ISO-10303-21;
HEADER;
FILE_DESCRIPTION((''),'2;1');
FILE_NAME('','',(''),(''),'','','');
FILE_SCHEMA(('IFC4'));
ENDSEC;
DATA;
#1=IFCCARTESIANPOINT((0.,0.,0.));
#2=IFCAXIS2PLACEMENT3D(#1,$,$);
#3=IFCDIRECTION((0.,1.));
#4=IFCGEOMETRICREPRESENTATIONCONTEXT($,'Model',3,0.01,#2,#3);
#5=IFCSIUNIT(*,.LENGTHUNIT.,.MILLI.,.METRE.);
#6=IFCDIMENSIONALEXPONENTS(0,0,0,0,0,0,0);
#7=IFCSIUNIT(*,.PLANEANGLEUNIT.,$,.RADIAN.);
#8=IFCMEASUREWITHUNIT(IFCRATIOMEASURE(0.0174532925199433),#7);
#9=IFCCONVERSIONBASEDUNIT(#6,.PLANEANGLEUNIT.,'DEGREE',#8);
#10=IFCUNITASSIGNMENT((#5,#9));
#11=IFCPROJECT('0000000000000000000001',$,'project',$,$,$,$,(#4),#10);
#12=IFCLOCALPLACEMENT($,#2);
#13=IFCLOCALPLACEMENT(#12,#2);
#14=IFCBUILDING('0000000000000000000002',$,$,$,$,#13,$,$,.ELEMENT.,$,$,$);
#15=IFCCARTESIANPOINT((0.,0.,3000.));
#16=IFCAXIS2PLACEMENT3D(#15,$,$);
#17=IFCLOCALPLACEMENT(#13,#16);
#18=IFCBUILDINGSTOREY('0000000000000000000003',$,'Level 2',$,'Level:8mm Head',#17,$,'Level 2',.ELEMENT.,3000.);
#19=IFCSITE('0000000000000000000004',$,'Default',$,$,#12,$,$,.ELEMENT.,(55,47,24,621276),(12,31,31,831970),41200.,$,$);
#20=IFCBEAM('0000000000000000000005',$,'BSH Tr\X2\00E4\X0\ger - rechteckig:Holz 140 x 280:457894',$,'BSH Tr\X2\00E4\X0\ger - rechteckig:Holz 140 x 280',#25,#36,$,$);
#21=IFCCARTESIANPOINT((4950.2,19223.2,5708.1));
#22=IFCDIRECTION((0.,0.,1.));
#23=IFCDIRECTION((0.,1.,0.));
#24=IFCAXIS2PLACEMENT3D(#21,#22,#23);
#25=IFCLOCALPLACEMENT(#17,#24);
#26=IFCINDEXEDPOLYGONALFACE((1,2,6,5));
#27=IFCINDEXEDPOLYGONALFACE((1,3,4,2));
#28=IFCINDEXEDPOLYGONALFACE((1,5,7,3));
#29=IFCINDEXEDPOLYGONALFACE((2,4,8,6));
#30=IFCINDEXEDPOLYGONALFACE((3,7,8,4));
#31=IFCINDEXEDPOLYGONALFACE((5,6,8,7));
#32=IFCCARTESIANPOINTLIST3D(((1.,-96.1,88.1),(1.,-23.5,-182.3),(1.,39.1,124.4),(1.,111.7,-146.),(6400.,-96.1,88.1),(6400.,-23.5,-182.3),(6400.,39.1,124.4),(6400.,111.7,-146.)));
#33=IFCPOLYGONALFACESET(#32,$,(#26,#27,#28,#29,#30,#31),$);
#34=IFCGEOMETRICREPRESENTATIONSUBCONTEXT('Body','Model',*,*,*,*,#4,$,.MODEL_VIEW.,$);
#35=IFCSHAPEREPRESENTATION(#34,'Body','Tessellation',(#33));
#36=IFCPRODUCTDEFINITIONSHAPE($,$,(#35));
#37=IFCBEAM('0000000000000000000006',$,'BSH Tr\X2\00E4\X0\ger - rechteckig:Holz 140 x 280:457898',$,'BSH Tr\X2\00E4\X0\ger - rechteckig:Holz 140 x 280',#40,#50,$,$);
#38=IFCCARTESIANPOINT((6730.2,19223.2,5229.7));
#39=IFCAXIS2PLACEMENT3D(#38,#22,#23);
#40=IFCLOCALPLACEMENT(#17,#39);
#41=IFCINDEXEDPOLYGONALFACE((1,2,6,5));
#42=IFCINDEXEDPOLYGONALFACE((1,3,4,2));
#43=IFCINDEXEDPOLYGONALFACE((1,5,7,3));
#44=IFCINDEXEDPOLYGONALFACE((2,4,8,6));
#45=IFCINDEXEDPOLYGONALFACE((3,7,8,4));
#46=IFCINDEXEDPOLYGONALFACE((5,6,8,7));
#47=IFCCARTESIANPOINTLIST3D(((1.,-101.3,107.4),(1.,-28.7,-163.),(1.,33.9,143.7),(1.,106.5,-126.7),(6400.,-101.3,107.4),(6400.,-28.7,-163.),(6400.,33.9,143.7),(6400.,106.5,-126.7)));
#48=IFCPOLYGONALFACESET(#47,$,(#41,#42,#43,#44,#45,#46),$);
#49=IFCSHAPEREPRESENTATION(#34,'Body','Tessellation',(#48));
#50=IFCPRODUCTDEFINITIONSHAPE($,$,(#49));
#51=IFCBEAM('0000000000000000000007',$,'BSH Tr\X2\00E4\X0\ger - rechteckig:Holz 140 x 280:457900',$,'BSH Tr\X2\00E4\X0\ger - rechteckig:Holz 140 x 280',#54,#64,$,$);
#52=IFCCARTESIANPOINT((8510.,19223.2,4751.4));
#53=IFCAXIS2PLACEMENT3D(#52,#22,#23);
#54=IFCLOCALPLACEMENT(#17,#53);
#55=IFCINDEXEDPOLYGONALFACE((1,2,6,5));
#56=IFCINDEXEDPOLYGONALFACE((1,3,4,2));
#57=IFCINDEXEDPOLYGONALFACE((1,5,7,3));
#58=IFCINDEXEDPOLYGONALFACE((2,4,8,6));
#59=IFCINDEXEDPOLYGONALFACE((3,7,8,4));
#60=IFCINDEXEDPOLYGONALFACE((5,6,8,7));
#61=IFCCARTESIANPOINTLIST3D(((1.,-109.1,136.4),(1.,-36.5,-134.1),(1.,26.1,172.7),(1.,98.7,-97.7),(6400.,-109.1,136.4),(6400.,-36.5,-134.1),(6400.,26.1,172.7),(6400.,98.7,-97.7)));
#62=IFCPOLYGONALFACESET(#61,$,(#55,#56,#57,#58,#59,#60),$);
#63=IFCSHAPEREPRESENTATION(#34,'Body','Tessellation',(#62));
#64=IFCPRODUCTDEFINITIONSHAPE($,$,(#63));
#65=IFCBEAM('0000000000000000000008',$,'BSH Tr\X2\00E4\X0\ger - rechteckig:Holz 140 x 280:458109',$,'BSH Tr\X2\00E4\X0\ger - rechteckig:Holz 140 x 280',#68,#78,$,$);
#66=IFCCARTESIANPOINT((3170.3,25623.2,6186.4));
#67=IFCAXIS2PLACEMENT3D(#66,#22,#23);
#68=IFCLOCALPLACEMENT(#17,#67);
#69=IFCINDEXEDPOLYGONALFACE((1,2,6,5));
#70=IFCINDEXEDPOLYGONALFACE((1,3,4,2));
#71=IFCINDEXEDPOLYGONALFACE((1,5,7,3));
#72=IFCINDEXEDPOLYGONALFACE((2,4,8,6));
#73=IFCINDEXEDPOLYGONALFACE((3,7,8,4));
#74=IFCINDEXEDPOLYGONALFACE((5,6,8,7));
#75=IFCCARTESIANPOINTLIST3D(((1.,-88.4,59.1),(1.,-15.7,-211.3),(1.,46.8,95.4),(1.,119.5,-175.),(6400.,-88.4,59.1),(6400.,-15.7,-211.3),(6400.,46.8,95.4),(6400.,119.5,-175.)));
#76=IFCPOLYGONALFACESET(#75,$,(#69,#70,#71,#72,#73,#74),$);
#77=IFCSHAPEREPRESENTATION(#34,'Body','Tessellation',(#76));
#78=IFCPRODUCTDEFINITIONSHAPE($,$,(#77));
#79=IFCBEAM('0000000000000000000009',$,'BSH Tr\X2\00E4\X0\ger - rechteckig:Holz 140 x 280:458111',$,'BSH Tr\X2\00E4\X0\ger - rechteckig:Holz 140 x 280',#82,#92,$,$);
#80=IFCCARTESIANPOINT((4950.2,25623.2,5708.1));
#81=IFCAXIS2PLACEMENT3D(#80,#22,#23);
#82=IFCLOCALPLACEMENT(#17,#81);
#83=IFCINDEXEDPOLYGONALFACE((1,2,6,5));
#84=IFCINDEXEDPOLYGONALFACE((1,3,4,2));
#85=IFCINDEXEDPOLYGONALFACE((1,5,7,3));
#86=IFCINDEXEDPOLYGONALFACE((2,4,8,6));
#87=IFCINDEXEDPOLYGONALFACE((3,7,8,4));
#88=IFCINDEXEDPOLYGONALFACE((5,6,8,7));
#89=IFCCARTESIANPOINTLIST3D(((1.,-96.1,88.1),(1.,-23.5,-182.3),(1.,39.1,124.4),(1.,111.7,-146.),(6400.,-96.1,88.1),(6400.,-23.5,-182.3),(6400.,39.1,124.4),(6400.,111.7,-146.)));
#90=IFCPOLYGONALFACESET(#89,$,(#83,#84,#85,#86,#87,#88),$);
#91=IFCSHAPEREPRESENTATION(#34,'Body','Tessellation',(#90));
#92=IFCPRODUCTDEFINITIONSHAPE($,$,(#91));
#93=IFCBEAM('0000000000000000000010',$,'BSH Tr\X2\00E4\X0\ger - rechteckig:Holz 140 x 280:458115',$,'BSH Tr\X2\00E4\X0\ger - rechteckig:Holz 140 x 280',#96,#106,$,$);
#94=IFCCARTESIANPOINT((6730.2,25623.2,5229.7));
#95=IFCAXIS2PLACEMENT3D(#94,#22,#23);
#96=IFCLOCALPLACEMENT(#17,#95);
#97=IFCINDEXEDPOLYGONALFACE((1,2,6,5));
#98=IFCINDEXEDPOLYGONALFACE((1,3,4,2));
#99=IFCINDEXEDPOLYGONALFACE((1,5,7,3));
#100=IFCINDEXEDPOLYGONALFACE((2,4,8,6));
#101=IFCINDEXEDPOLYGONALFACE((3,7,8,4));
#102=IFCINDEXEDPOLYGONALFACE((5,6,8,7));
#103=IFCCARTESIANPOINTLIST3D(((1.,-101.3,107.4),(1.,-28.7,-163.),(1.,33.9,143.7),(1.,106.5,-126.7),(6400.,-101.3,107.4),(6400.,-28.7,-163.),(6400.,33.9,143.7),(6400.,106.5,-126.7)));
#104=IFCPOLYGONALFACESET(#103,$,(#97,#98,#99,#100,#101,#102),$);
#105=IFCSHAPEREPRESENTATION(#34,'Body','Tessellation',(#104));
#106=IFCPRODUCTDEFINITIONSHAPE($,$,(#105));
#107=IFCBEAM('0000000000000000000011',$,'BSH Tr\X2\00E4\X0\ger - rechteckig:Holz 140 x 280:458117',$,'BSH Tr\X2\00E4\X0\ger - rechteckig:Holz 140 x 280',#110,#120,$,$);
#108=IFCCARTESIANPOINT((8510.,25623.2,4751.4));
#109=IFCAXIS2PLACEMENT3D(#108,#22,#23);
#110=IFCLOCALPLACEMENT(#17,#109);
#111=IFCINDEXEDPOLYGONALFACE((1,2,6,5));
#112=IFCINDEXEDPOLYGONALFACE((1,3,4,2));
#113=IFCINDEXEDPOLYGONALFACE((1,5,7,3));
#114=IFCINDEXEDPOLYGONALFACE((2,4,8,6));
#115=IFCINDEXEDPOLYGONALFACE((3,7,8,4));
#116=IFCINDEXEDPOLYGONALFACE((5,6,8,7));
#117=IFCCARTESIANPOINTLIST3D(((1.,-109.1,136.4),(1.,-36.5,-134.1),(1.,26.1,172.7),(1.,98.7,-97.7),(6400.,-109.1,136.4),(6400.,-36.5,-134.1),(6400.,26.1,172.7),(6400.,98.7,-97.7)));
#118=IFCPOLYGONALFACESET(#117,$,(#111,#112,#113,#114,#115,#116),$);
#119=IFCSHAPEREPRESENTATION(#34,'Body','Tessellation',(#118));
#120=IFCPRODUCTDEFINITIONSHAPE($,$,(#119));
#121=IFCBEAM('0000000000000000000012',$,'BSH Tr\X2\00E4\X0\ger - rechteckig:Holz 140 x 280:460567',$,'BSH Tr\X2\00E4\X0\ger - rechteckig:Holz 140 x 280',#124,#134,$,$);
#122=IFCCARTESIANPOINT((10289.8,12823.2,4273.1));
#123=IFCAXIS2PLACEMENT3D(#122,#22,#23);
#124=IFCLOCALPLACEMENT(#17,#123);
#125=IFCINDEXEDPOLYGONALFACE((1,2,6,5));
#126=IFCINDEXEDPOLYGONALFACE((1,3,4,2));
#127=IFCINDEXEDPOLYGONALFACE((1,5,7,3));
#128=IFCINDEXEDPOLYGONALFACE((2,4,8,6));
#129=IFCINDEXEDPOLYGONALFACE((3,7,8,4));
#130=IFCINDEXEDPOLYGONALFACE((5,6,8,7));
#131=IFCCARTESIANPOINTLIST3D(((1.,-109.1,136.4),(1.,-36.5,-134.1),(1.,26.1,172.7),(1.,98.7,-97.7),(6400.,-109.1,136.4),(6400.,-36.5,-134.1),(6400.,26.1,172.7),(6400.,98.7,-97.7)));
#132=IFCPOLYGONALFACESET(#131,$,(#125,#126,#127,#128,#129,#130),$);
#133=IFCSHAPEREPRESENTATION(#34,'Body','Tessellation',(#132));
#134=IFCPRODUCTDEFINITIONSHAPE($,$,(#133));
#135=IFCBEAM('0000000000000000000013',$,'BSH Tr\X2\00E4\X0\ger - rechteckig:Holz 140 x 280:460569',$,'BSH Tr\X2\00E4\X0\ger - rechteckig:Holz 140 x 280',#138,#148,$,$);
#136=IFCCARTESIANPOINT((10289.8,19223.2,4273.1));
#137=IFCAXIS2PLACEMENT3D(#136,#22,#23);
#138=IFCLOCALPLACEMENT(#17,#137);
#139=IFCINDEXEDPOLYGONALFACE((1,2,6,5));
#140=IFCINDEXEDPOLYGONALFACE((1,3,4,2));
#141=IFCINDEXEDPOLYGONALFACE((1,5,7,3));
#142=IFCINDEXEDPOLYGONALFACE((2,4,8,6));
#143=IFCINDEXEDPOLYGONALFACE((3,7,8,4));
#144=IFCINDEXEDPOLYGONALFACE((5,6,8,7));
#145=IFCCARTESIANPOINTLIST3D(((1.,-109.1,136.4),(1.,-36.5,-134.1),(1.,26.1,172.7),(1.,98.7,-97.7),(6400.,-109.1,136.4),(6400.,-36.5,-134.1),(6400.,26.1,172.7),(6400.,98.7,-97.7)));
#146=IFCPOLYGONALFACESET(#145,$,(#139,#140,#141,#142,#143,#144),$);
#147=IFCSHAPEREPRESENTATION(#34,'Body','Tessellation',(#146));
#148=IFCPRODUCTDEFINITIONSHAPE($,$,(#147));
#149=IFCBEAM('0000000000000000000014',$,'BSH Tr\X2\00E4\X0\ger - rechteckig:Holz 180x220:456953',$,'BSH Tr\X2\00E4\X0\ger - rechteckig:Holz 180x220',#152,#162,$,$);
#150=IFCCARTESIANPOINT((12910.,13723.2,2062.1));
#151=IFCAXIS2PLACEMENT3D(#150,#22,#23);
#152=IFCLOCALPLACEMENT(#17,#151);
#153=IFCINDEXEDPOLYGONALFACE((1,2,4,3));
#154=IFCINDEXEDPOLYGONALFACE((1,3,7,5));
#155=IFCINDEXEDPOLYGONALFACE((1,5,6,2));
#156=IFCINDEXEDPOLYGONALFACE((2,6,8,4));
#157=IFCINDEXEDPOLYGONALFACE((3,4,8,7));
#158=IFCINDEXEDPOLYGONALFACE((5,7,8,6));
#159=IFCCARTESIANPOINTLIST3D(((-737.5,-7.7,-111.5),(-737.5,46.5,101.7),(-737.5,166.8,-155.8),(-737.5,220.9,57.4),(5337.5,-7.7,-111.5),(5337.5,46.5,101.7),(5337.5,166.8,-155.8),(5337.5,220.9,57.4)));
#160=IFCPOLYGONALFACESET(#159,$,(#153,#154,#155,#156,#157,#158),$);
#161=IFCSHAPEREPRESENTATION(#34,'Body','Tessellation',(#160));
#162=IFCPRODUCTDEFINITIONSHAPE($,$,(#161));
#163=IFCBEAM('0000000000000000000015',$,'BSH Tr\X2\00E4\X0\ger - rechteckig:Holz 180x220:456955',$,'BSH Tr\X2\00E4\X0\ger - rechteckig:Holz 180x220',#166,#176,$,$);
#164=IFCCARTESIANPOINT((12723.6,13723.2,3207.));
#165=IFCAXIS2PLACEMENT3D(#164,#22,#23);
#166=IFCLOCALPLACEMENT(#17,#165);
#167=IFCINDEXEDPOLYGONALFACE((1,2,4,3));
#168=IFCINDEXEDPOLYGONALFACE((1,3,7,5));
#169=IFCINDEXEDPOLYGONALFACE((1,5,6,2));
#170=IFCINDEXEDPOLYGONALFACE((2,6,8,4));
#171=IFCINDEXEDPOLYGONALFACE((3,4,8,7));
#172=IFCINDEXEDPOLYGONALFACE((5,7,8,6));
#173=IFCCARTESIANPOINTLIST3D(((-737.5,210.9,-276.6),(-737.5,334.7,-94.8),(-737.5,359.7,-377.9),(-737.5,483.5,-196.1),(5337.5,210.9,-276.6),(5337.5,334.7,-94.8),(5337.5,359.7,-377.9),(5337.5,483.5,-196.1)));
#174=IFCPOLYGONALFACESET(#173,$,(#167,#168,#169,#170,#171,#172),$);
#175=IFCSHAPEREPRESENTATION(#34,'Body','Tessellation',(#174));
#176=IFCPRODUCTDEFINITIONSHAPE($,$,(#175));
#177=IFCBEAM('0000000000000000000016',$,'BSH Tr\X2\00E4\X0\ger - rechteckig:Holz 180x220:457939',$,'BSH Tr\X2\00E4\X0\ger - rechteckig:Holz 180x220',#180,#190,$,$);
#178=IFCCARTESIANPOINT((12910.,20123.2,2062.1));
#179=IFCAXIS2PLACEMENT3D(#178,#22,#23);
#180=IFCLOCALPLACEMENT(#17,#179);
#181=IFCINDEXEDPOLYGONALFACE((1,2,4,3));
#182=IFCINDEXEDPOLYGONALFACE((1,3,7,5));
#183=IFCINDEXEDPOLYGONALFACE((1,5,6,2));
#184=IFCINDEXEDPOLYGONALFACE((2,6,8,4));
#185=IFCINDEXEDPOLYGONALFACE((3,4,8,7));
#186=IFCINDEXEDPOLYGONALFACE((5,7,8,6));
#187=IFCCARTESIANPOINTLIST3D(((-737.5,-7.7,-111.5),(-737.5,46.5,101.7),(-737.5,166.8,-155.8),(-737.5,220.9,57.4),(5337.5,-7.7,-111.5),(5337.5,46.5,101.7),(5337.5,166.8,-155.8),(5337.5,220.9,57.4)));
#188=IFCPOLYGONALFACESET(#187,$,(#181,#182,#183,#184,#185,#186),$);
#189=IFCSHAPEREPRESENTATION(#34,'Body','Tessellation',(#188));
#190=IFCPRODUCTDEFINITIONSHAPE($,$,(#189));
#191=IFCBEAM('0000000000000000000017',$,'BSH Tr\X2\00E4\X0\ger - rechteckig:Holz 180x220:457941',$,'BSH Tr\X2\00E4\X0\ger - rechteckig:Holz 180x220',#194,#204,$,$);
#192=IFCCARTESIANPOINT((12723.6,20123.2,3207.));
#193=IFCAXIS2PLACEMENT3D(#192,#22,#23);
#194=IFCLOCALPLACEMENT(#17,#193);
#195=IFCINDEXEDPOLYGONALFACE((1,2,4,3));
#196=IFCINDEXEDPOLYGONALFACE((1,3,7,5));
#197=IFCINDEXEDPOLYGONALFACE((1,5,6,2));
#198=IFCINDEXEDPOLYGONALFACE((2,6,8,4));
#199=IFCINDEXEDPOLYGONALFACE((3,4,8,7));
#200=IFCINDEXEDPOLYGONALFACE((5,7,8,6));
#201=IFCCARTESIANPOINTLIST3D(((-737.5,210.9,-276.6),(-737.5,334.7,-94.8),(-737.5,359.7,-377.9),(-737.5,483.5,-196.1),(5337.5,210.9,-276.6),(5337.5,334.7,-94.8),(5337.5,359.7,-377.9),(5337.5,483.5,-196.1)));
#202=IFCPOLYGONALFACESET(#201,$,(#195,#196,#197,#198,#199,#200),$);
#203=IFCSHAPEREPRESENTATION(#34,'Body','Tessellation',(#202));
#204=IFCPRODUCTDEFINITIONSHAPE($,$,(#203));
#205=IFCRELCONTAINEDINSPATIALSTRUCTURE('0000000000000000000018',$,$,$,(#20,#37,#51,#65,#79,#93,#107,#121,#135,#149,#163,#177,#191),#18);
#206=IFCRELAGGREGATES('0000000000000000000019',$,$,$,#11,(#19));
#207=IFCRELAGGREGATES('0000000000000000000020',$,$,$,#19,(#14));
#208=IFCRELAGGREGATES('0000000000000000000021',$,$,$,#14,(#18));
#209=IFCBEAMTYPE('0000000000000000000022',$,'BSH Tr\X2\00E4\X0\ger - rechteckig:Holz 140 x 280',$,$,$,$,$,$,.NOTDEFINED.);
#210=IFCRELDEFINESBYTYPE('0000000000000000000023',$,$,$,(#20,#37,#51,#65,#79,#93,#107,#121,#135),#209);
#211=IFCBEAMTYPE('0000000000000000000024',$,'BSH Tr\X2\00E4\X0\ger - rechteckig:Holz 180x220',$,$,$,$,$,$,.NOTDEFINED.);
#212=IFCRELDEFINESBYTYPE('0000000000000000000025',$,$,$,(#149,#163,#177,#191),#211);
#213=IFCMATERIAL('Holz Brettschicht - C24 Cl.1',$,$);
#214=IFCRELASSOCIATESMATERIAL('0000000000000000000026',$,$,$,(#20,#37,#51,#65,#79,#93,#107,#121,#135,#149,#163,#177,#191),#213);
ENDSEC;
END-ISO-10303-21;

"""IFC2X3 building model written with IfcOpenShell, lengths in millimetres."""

from ifc_helpers import new_model, entity, si_unit, converted_unit, direction, frame, frame_2d, origin, place, context, subcontext, project, spatial, rectangle, extrude, material, type_object, element, save


model = new_model("IFC2X3")

# Units and contexts
model_context = context("Model", 3, precision=0.01, world=origin(), true_north=direction((0.0, 1.0)))
body_context = subcontext(model_context, "Body", "Model", "MODEL_VIEW")
ifc_project = project(units=[si_unit("LENGTHUNIT", "METRE", prefix="MILLI"), converted_unit("PLANEANGLEUNIT", "DEGREE", entity("IfcRatioMeasure", 0.0174532925199433), si_unit("PLANEANGLEUNIT", "RADIAN"), dimensions=[0, 0, 0, 0, 0, 0, 0])], contexts=[model_context])

# Site, building, storey
site_placement = place(None, origin())
site = spatial("IfcSite", under=ifc_project, at=site_placement, Name="Default", CompositionType="ELEMENT", RefLatitude=(55, 47, 24, 621276), RefLongitude=(12, 31, 31, 831970), RefElevation=41200.0)
building_placement = place(site_placement, origin())
building = spatial("IfcBuilding", under=site, at=building_placement, CompositionType="ELEMENT")
storey_placement = place(building_placement, frame((0.0, 0.0, 3000.0)))
storey = spatial("IfcBuildingStorey", under=building, at=storey_placement, Name="Level 2", ObjectType="Level:8mm Head", LongName="Level 2", CompositionType="ELEMENT", Elevation=3000.0)

# Beams
ifc_material = material(Name="Holz Brettschicht - C24 Cl.1")
beam_type_1 = type_object("IfcBeamType", Name="BSH Träger - rechteckig:Holz 140 x 280", PredefinedType="NOTDEFINED")
beam_1_placement = place(storey_placement, frame((4950.2, 19223.2, 5708.1), z_axis=(0.0, 0.0, 1.0), x_axis=(0.0, 1.0, 0.0)))
element("IfcBeam", 1, at=beam_1_placement, inside=storey, type_object=beam_type_1, material=ifc_material, Name="BSH Träger - rechteckig:Holz 140 x 280:457894", ObjectType="BSH Träger - rechteckig:Holz 140 x 280", context=body_context, shape_type="SweptSolid", body=[
    extrude(rectangle(XDim=280.0, YDim=140.0, at=frame_2d((0.0, 0.0), x_axis=(1.0, 0.0))), frame((1.0, 7.8, -29.0), z_axis=(1.0, 0.0, 0.0), x_axis=(0.0, -0.259528, 0.965735)), (0.0, 0.0, 1.0), 6399.0),
])
beam_2_placement = place(storey_placement, frame((6730.2, 19223.2, 5229.7), z_axis=(0.0, 0.0, 1.0), x_axis=(0.0, 1.0, 0.0)))
element("IfcBeam", 2, at=beam_2_placement, inside=storey, type_object=beam_type_1, material=ifc_material, Name="BSH Träger - rechteckig:Holz 140 x 280:457898", ObjectType="BSH Träger - rechteckig:Holz 140 x 280", context=body_context, shape_type="SweptSolid", body=[
    extrude(rectangle(XDim=280.0, YDim=140.0, at=frame_2d((0.0, 0.0), x_axis=(1.0, 0.0))), frame((1.0, 2.6, -9.7), z_axis=(1.0, 0.0, 0.0), x_axis=(0.0, -0.259528, 0.965735)), (0.0, 0.0, 1.0), 6399.0),
])
beam_3_placement = place(storey_placement, frame((8510.0, 19223.2, 4751.4), z_axis=(0.0, 0.0, 1.0), x_axis=(0.0, 1.0, 0.0)))
element("IfcBeam", 3, at=beam_3_placement, inside=storey, type_object=beam_type_1, material=ifc_material, Name="BSH Träger - rechteckig:Holz 140 x 280:457900", ObjectType="BSH Träger - rechteckig:Holz 140 x 280", context=body_context, shape_type="SweptSolid", body=[
    extrude(rectangle(XDim=280.0, YDim=140.0, at=frame_2d((0.0, 0.0), x_axis=(1.0, 0.0))), frame((1.0, -5.2, 19.3), z_axis=(1.0, 0.0, 0.0), x_axis=(0.0, -0.259528, 0.965735)), (0.0, 0.0, 1.0), 6399.0),
])
beam_4_placement = place(storey_placement, frame((3170.3, 25623.2, 6186.4), z_axis=(0.0, 0.0, 1.0), x_axis=(0.0, 1.0, 0.0)))
element("IfcBeam", 4, at=beam_4_placement, inside=storey, type_object=beam_type_1, material=ifc_material, Name="BSH Träger - rechteckig:Holz 140 x 280:458109", ObjectType="BSH Träger - rechteckig:Holz 140 x 280", context=body_context, shape_type="SweptSolid", body=[
    extrude(rectangle(XDim=280.0, YDim=140.0, at=frame_2d((0.0, 0.0), x_axis=(1.0, 0.0))), frame((1.0, 15.6, -57.9), z_axis=(1.0, 0.0, 0.0), x_axis=(0.0, -0.259528, 0.965735)), (0.0, 0.0, 1.0), 6399.0),
])
beam_5_placement = place(storey_placement, frame((4950.2, 25623.2, 5708.1), z_axis=(0.0, 0.0, 1.0), x_axis=(0.0, 1.0, 0.0)))
element("IfcBeam", 5, at=beam_5_placement, inside=storey, type_object=beam_type_1, material=ifc_material, Name="BSH Träger - rechteckig:Holz 140 x 280:458111", ObjectType="BSH Träger - rechteckig:Holz 140 x 280", context=body_context, shape_type="SweptSolid", body=[
    extrude(rectangle(XDim=280.0, YDim=140.0, at=frame_2d((0.0, 0.0), x_axis=(1.0, 0.0))), frame((1.0, 7.8, -29.0), z_axis=(1.0, 0.0, 0.0), x_axis=(0.0, -0.259528, 0.965735)), (0.0, 0.0, 1.0), 6399.0),
])
beam_6_placement = place(storey_placement, frame((6730.2, 25623.2, 5229.7), z_axis=(0.0, 0.0, 1.0), x_axis=(0.0, 1.0, 0.0)))
element("IfcBeam", 6, at=beam_6_placement, inside=storey, type_object=beam_type_1, material=ifc_material, Name="BSH Träger - rechteckig:Holz 140 x 280:458115", ObjectType="BSH Träger - rechteckig:Holz 140 x 280", context=body_context, shape_type="SweptSolid", body=[
    extrude(rectangle(XDim=280.0, YDim=140.0, at=frame_2d((0.0, 0.0), x_axis=(1.0, 0.0))), frame((1.0, 2.6, -9.7), z_axis=(1.0, 0.0, 0.0), x_axis=(0.0, -0.259528, 0.965735)), (0.0, 0.0, 1.0), 6399.0),
])
beam_7_placement = place(storey_placement, frame((8510.0, 25623.2, 4751.4), z_axis=(0.0, 0.0, 1.0), x_axis=(0.0, 1.0, 0.0)))
element("IfcBeam", 7, at=beam_7_placement, inside=storey, type_object=beam_type_1, material=ifc_material, Name="BSH Träger - rechteckig:Holz 140 x 280:458117", ObjectType="BSH Träger - rechteckig:Holz 140 x 280", context=body_context, shape_type="SweptSolid", body=[
    extrude(rectangle(XDim=280.0, YDim=140.0, at=frame_2d((0.0, 0.0), x_axis=(1.0, 0.0))), frame((1.0, -5.2, 19.3), z_axis=(1.0, 0.0, 0.0), x_axis=(0.0, -0.259528, 0.965735)), (0.0, 0.0, 1.0), 6399.0),
])
beam_8_placement = place(storey_placement, frame((10289.8, 12823.2, 4273.1), z_axis=(0.0, 0.0, 1.0), x_axis=(0.0, 1.0, 0.0)))
element("IfcBeam", 8, at=beam_8_placement, inside=storey, type_object=beam_type_1, material=ifc_material, Name="BSH Träger - rechteckig:Holz 140 x 280:460567", ObjectType="BSH Träger - rechteckig:Holz 140 x 280", context=body_context, shape_type="SweptSolid", body=[
    extrude(rectangle(XDim=280.0, YDim=140.0, at=frame_2d((0.0, 0.0), x_axis=(1.0, 0.0))), frame((1.0, -5.2, 19.3), z_axis=(1.0, 0.0, 0.0), x_axis=(0.0, -0.259528, 0.965735)), (0.0, 0.0, 1.0), 6399.0),
])
beam_9_placement = place(storey_placement, frame((10289.8, 19223.2, 4273.1), z_axis=(0.0, 0.0, 1.0), x_axis=(0.0, 1.0, 0.0)))
element("IfcBeam", 9, at=beam_9_placement, inside=storey, type_object=beam_type_1, material=ifc_material, Name="BSH Träger - rechteckig:Holz 140 x 280:460569", ObjectType="BSH Träger - rechteckig:Holz 140 x 280", context=body_context, shape_type="SweptSolid", body=[
    extrude(rectangle(XDim=280.0, YDim=140.0, at=frame_2d((0.0, 0.0), x_axis=(1.0, 0.0))), frame((1.0, -5.2, 19.3), z_axis=(1.0, 0.0, 0.0), x_axis=(0.0, -0.259528, 0.965735)), (0.0, 0.0, 1.0), 6399.0),
])
beam_type_2 = type_object("IfcBeamType", Name="BSH Träger - rechteckig:Holz 180x220", PredefinedType="NOTDEFINED")
beam_10_placement = place(storey_placement, frame((12910.0, 13723.2, 2062.1), z_axis=(0.0, 0.0, 1.0), x_axis=(0.0, 1.0, 0.0)))
element("IfcBeam", 10, at=beam_10_placement, inside=storey, type_object=beam_type_2, material=ifc_material, Name="BSH Träger - rechteckig:Holz 180x220:456953", ObjectType="BSH Träger - rechteckig:Holz 180x220", context=body_context, shape_type="SweptSolid", body=[
    extrude(rectangle(XDim=220.0, YDim=180.0, at=frame_2d((0.0, 0.0), x_axis=(1.0, 0.0))), frame((-737.5, 106.6, -27.1), z_axis=(1.0, 0.0, 0.0), x_axis=(0.0, 0.246135, 0.969236)), (0.0, 0.0, 1.0), 6075.0),
])
beam_11_placement = place(storey_placement, frame((12723.6, 13723.2, 3207.0), z_axis=(0.0, 0.0, 1.0), x_axis=(0.0, 1.0, 0.0)))
element("IfcBeam", 11, at=beam_11_placement, inside=storey, type_object=beam_type_2, material=ifc_material, Name="BSH Träger - rechteckig:Holz 180x220:456955", ObjectType="BSH Träger - rechteckig:Holz 180x220", context=body_context, shape_type="SweptSolid", body=[
    extrude(rectangle(XDim=220.0, YDim=180.0, at=frame_2d((0.0, 0.0), x_axis=(1.0, 0.0))), frame((-737.5, 347.2, -236.4), z_axis=(1.0, 0.0, 0.0), x_axis=(0.0, 0.562789, 0.826601)), (0.0, 0.0, 1.0), 6075.0),
])
beam_12_placement = place(storey_placement, frame((12910.0, 20123.2, 2062.1), z_axis=(0.0, 0.0, 1.0), x_axis=(0.0, 1.0, 0.0)))
element("IfcBeam", 12, at=beam_12_placement, inside=storey, type_object=beam_type_2, material=ifc_material, Name="BSH Träger - rechteckig:Holz 180x220:457939", ObjectType="BSH Träger - rechteckig:Holz 180x220", context=body_context, shape_type="SweptSolid", body=[
    extrude(rectangle(XDim=220.0, YDim=180.0, at=frame_2d((0.0, 0.0), x_axis=(1.0, 0.0))), frame((-737.5, 106.6, -27.1), z_axis=(1.0, 0.0, 0.0), x_axis=(0.0, 0.246135, 0.969236)), (0.0, 0.0, 1.0), 6075.0),
])
beam_13_placement = place(storey_placement, frame((12723.6, 20123.2, 3207.0), z_axis=(0.0, 0.0, 1.0), x_axis=(0.0, 1.0, 0.0)))
element("IfcBeam", 13, at=beam_13_placement, inside=storey, type_object=beam_type_2, material=ifc_material, Name="BSH Träger - rechteckig:Holz 180x220:457941", ObjectType="BSH Träger - rechteckig:Holz 180x220", context=body_context, shape_type="SweptSolid", body=[
    extrude(rectangle(XDim=220.0, YDim=180.0, at=frame_2d((0.0, 0.0), x_axis=(1.0, 0.0))), frame((-737.5, 347.2, -236.4), z_axis=(1.0, 0.0, 0.0), x_axis=(0.0, 0.562789, 0.826601)), (0.0, 0.0, 1.0), 6075.0),
])

save(model, "model.ifc")
